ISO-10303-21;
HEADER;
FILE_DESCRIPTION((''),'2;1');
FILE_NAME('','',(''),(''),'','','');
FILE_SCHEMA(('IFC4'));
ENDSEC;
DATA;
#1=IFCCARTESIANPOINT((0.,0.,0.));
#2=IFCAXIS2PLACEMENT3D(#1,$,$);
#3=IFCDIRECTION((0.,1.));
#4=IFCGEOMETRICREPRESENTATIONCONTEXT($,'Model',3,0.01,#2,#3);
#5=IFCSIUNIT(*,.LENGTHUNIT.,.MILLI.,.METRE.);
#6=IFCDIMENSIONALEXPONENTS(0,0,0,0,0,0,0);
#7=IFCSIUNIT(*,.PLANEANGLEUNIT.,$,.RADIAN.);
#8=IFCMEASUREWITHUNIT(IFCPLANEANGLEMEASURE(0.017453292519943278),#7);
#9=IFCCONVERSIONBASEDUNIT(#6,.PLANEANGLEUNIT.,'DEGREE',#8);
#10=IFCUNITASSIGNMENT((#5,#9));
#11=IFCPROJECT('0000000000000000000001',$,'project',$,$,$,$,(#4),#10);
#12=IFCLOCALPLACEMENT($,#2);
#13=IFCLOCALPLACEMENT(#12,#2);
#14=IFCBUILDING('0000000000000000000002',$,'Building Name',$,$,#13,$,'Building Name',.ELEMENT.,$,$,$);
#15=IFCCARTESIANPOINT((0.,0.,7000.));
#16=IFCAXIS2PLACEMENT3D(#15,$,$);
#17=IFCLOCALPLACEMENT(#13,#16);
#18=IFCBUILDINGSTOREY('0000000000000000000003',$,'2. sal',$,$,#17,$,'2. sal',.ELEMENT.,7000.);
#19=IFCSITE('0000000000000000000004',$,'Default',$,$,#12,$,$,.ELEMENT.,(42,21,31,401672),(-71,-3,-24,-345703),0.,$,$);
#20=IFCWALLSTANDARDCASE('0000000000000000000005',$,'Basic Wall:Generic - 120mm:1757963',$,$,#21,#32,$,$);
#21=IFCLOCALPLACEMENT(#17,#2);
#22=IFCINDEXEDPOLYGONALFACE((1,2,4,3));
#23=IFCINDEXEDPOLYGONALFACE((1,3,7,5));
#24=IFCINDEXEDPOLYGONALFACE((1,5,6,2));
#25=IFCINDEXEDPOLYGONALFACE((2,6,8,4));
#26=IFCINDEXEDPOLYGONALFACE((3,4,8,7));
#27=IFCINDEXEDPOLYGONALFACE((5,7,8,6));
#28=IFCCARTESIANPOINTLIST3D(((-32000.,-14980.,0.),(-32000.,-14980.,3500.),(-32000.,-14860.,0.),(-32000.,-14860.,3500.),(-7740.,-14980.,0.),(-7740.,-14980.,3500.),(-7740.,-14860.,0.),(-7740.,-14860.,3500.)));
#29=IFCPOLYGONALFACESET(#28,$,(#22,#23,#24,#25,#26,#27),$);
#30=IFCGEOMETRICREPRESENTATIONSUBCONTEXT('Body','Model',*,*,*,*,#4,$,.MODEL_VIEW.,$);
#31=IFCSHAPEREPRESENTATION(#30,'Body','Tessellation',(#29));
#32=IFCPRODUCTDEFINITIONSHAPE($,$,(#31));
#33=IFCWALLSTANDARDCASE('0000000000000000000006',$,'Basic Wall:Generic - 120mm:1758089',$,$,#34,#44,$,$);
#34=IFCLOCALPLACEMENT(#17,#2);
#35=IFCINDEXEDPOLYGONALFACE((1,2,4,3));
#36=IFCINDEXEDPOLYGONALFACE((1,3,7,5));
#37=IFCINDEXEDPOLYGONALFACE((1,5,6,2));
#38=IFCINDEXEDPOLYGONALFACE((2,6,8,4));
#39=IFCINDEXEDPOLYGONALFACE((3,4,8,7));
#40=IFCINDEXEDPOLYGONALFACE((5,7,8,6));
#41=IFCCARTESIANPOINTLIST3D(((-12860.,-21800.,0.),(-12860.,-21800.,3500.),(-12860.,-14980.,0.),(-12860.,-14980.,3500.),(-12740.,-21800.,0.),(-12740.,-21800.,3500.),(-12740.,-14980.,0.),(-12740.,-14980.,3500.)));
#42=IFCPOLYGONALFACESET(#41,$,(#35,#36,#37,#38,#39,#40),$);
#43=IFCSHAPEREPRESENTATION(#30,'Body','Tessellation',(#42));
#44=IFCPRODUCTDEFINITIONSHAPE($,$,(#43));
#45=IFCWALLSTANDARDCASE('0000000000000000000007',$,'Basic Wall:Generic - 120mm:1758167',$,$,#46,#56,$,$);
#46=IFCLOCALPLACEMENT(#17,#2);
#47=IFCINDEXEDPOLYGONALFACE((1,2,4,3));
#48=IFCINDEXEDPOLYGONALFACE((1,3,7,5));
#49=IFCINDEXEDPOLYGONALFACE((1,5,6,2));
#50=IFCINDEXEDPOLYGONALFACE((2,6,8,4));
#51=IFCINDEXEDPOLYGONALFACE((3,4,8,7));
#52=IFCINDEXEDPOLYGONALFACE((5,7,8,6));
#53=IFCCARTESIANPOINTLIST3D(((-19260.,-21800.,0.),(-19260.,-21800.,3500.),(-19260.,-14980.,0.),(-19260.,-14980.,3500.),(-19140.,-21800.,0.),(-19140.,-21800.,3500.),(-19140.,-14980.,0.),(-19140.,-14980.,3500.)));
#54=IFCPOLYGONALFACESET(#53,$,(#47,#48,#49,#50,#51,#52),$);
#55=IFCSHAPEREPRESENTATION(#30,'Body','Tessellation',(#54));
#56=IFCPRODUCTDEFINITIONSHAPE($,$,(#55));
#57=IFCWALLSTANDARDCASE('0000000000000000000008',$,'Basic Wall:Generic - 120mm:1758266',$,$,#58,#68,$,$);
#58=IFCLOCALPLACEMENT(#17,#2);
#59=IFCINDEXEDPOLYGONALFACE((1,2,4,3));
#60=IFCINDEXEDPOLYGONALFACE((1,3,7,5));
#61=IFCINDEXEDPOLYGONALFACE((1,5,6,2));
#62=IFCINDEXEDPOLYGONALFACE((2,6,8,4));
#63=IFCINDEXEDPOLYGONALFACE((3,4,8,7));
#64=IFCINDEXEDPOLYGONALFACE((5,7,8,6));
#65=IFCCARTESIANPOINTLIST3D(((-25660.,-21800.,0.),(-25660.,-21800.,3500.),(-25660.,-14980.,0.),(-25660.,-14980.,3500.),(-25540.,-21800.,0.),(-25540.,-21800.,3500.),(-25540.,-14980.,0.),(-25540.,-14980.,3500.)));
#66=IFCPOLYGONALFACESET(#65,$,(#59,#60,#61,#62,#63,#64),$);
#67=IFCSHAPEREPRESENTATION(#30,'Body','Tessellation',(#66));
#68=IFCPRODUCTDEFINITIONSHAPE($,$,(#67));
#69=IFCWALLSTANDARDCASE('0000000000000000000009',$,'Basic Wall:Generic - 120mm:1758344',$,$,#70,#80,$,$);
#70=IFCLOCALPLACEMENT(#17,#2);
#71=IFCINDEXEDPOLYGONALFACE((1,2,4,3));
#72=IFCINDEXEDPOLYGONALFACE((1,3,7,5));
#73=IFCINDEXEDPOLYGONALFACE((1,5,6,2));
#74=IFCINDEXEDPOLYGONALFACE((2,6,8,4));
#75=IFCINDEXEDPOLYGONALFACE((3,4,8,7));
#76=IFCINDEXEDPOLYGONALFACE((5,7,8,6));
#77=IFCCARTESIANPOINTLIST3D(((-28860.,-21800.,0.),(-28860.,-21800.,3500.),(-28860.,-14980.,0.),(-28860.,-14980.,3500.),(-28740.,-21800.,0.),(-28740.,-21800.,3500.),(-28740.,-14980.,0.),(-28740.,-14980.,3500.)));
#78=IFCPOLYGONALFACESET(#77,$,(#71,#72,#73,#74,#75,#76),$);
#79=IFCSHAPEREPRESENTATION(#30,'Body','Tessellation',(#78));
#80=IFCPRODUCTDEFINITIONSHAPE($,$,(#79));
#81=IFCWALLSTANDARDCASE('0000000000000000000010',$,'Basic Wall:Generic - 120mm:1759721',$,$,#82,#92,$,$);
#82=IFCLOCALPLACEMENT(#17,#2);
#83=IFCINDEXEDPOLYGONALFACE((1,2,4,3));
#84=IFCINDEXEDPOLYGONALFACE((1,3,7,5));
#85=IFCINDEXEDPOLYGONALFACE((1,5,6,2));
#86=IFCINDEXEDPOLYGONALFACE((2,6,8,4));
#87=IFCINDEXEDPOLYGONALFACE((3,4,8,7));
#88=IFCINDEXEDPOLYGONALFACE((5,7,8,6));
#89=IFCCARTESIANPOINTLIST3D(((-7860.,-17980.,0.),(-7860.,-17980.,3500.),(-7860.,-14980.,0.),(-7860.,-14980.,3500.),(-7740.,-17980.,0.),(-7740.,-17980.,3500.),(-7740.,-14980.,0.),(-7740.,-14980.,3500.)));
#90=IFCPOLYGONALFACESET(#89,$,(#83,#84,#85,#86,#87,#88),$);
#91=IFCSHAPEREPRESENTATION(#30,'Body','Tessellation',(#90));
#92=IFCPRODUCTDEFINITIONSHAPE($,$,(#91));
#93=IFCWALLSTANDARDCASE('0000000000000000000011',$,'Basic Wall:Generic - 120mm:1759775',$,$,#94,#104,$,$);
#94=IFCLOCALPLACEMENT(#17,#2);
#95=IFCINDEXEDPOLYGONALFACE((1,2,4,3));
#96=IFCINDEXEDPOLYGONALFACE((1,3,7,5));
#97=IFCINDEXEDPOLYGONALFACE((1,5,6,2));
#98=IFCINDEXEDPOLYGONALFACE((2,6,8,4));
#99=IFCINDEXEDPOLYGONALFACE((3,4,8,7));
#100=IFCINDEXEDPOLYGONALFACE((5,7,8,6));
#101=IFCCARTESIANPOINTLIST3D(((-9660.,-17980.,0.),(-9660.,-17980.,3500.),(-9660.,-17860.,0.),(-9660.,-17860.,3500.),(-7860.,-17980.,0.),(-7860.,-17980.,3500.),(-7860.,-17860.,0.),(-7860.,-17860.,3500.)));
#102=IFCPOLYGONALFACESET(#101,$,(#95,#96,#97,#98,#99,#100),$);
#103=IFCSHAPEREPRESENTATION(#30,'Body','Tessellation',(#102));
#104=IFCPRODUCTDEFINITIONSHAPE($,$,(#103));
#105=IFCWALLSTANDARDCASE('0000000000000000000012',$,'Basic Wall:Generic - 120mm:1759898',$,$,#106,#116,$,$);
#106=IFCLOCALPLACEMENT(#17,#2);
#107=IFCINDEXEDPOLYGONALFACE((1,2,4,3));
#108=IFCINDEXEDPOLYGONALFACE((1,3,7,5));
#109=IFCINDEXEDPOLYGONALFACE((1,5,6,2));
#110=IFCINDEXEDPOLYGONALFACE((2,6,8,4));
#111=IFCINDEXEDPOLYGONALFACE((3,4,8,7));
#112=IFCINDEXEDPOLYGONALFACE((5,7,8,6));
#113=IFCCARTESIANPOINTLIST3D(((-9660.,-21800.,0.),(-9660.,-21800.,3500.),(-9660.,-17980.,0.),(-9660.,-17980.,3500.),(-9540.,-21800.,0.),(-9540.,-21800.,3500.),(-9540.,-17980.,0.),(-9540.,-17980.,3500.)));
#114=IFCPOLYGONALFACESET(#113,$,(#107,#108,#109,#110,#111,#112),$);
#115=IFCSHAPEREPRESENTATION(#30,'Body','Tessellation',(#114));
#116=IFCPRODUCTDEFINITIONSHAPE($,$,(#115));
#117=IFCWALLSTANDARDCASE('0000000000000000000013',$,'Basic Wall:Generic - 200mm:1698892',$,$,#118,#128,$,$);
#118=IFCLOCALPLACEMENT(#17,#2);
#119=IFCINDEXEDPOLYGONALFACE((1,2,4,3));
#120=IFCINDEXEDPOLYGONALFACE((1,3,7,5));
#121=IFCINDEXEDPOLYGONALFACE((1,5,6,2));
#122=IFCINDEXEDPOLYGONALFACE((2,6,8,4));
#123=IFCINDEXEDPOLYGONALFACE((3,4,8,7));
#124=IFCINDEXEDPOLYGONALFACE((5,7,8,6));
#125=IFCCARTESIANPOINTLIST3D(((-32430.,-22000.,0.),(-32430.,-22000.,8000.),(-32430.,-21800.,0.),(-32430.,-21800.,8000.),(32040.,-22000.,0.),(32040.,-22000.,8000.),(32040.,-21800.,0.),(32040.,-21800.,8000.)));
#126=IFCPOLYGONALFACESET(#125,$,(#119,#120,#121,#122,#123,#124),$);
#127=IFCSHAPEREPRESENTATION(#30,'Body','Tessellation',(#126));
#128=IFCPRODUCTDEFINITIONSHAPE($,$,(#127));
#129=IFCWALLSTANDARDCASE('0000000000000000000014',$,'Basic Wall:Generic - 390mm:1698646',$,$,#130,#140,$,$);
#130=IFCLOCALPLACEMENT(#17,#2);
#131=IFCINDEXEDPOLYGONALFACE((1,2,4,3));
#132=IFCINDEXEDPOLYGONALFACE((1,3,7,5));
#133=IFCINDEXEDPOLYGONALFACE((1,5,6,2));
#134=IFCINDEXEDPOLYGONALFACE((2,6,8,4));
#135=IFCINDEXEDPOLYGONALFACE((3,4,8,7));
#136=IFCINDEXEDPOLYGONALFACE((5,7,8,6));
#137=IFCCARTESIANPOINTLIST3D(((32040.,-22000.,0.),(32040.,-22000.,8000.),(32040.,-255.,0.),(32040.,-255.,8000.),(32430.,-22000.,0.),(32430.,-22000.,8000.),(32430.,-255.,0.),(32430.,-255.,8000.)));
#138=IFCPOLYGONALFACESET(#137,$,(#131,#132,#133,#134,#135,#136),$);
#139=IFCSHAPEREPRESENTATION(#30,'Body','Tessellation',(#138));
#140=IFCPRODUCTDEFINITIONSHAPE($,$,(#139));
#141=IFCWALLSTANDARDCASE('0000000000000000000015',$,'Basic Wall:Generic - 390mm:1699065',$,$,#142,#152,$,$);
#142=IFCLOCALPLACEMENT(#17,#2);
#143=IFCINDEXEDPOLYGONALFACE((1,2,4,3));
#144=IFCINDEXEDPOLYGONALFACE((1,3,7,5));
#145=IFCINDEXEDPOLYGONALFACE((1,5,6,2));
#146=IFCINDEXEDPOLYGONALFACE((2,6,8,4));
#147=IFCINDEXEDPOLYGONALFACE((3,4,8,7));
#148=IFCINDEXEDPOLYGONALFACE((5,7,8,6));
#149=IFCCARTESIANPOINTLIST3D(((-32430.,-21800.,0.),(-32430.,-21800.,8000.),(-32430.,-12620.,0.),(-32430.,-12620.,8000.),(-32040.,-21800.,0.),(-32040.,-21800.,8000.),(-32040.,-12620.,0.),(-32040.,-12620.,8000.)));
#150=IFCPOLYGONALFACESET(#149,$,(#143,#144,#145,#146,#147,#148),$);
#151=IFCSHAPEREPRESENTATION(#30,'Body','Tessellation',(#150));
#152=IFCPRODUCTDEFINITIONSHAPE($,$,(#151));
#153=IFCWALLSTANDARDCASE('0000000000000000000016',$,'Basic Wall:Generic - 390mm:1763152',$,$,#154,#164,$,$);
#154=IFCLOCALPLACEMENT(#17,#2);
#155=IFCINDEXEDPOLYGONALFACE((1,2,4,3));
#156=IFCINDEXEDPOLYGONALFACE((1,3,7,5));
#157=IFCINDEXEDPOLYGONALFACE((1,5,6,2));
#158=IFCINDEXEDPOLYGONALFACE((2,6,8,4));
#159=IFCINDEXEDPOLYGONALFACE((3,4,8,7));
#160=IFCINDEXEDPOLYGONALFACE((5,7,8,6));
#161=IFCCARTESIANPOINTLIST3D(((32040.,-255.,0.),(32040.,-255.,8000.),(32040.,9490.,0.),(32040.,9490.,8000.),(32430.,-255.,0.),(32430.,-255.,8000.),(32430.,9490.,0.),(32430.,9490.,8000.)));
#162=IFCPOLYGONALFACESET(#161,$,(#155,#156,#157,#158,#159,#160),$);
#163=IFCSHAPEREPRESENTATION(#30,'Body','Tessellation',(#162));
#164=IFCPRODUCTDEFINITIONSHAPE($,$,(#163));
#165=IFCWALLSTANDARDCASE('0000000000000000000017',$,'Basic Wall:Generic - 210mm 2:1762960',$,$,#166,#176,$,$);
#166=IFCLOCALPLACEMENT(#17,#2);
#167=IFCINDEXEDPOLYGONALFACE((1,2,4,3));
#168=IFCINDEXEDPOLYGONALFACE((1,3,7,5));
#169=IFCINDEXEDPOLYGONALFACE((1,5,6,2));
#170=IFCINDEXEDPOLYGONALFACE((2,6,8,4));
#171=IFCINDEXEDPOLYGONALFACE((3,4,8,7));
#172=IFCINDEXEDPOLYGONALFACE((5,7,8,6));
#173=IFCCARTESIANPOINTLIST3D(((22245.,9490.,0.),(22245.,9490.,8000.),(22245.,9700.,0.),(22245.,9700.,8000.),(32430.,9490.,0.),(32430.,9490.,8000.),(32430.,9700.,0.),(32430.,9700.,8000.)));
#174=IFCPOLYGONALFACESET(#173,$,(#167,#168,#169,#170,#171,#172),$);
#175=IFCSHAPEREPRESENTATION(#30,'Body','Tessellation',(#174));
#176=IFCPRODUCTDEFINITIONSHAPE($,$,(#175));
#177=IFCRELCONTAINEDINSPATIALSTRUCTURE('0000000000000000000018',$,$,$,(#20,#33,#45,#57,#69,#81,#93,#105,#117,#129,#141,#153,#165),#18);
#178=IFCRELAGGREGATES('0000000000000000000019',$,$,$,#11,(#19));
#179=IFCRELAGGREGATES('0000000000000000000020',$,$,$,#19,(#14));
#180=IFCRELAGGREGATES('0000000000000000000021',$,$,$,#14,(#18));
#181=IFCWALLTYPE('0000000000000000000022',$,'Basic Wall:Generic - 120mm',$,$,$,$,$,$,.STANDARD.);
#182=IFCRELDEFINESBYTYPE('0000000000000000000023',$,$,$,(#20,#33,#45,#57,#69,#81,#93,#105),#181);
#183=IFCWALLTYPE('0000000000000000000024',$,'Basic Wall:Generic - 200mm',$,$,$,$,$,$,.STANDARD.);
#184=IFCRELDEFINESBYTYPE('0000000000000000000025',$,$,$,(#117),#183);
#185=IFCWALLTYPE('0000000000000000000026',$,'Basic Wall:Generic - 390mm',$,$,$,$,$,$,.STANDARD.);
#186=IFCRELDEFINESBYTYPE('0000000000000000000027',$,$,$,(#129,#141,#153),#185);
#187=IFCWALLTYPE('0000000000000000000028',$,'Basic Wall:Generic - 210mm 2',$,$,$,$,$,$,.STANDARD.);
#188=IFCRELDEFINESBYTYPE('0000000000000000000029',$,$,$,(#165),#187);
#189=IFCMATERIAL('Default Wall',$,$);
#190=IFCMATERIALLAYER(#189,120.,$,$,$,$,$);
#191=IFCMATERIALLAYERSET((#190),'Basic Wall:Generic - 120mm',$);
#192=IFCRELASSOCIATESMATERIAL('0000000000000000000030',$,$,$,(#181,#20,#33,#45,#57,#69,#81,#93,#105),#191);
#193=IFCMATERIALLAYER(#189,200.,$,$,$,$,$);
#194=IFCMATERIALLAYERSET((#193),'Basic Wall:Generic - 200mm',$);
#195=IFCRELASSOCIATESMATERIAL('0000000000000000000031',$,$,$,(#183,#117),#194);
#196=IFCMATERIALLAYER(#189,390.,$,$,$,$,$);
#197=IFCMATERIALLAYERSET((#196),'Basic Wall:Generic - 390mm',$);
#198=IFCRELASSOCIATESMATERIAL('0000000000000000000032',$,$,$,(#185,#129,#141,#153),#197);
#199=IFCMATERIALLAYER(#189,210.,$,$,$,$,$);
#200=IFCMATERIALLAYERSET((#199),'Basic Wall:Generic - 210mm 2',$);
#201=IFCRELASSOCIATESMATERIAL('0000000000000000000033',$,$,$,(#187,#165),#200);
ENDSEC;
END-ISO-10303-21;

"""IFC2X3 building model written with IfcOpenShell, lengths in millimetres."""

from ifc_helpers import new_model, entity, si_unit, converted_unit, direction, frame, frame_2d, origin, place, context, subcontext, project, spatial, rectangle, extrude, material, layer, layer_set, layer_usage, type_object, element, save


model = new_model("IFC2X3")

# Units and contexts
model_context = context("Model", 3, precision=0.01, world=origin(), true_north=direction((0.0, 1.0)))
body_context = subcontext(model_context, "Body", "Model", "MODEL_VIEW")
ifc_project = project(units=[si_unit("LENGTHUNIT", "METRE", prefix="MILLI"), converted_unit("PLANEANGLEUNIT", "DEGREE", entity("IfcPlaneAngleMeasure", 0.017453292519943278), si_unit("PLANEANGLEUNIT", "RADIAN"), dimensions=[0, 0, 0, 0, 0, 0, 0])], contexts=[model_context])

# Site, building, storey
site_placement = place(None, origin())
site = spatial("IfcSite", under=ifc_project, at=site_placement, Name="Default", CompositionType="ELEMENT", RefLatitude=(42, 21, 31, 401672), RefLongitude=(-71, -3, -24, -345703), RefElevation=0.0)
building_placement = place(site_placement, origin())
building = spatial("IfcBuilding", under=site, at=building_placement, Name="Building Name", LongName="Building Name", CompositionType="ELEMENT")
storey_placement = place(building_placement, frame((0.0, 0.0, 7000.0)))
storey = spatial("IfcBuildingStorey", under=building, at=storey_placement, Name="2. sal", LongName="2. sal", CompositionType="ELEMENT", Elevation=7000.0)

# Walls
ifc_material_1 = material(Name="Default Wall")
ifc_layer_1 = layer(ifc_material_1, 120.0)
ifc_layer_set_1 = layer_set([ifc_layer_1], Name="Basic Wall:Generic - 120mm")
ifc_layer_usage_1 = layer_usage(ifc_layer_set_1, "AXIS2", "NEGATIVE", 60.0)
wall_type_1 = type_object("IfcWallType", Name="Basic Wall:Generic - 120mm", PredefinedType="STANDARD", material=ifc_layer_set_1)
wall_1_placement = place(storey_placement, frame((-32000.0, -14920.0, 0.0)))
element("IfcWallStandardCase", 1, at=wall_1_placement, inside=storey, type_object=wall_type_1, material=ifc_layer_usage_1, Name="Basic Wall:Generic - 120mm:1757963", context=body_context, shape_type="SweptSolid", body=[
    extrude(rectangle(XDim=24260.0, YDim=120.0, at=frame_2d((12130.0, 0.0), x_axis=(-1.0, 0.0))), origin(), (0.0, 0.0, 1.0), 3500.0),
])
ifc_layer_usage_2 = layer_usage(ifc_layer_set_1, "AXIS2", "NEGATIVE", 60.0)
wall_2_placement = place(storey_placement, frame((-12800.0, -14980.0, 0.0), z_axis=(0.0, 0.0, 1.0), x_axis=(0.0, -1.0, 0.0)))
element("IfcWallStandardCase", 2, at=wall_2_placement, inside=storey, type_object=wall_type_1, material=ifc_layer_usage_2, Name="Basic Wall:Generic - 120mm:1758089", context=body_context, shape_type="SweptSolid", body=[
    extrude(rectangle(XDim=6820.0, YDim=120.0, at=frame_2d((3410.0, 0.0), x_axis=(-1.0, 0.0))), origin(), (0.0, 0.0, 1.0), 3500.0),
])
ifc_layer_usage_3 = layer_usage(ifc_layer_set_1, "AXIS2", "NEGATIVE", 60.0)
wall_3_placement = place(storey_placement, frame((-19200.0, -14980.0, 0.0), z_axis=(0.0, 0.0, 1.0), x_axis=(0.0, -1.0, 0.0)))
element("IfcWallStandardCase", 3, at=wall_3_placement, inside=storey, type_object=wall_type_1, material=ifc_layer_usage_3, Name="Basic Wall:Generic - 120mm:1758167", context=body_context, shape_type="SweptSolid", body=[
    extrude(rectangle(XDim=6820.0, YDim=120.0, at=frame_2d((3410.0, 0.0), x_axis=(-1.0, 0.0))), origin(), (0.0, 0.0, 1.0), 3500.0),
])
ifc_layer_usage_4 = layer_usage(ifc_layer_set_1, "AXIS2", "NEGATIVE", 60.0)
wall_4_placement = place(storey_placement, frame((-25600.0, -14980.0, 0.0), z_axis=(0.0, 0.0, 1.0), x_axis=(0.0, -1.0, 0.0)))
element("IfcWallStandardCase", 4, at=wall_4_placement, inside=storey, type_object=wall_type_1, material=ifc_layer_usage_4, Name="Basic Wall:Generic - 120mm:1758266", context=body_context, shape_type="SweptSolid", body=[
    extrude(rectangle(XDim=6820.0, YDim=120.0, at=frame_2d((3410.0, 0.0), x_axis=(-1.0, 0.0))), origin(), (0.0, 0.0, 1.0), 3500.0),
])
ifc_layer_usage_5 = layer_usage(ifc_layer_set_1, "AXIS2", "NEGATIVE", 60.0)
wall_5_placement = place(storey_placement, frame((-28800.0, -14980.0, 0.0), z_axis=(0.0, 0.0, 1.0), x_axis=(0.0, -1.0, 0.0)))
element("IfcWallStandardCase", 5, at=wall_5_placement, inside=storey, type_object=wall_type_1, material=ifc_layer_usage_5, Name="Basic Wall:Generic - 120mm:1758344", context=body_context, shape_type="SweptSolid", body=[
    extrude(rectangle(XDim=6820.0, YDim=120.0, at=frame_2d((3410.0, 0.0), x_axis=(-1.0, 0.0))), origin(), (0.0, 0.0, 1.0), 3500.0),
])
ifc_layer_usage_6 = layer_usage(ifc_layer_set_1, "AXIS2", "NEGATIVE", 60.0)
wall_6_placement = place(storey_placement, frame((-7800.0, -14980.0, 0.0), z_axis=(0.0, 0.0, 1.0), x_axis=(0.0, -1.0, 0.0)))
element("IfcWallStandardCase", 6, at=wall_6_placement, inside=storey, type_object=wall_type_1, material=ifc_layer_usage_6, Name="Basic Wall:Generic - 120mm:1759721", context=body_context, shape_type="SweptSolid", body=[
    extrude(rectangle(XDim=3000.0, YDim=120.0, at=frame_2d((1500.0, 0.0), x_axis=(-1.0, 0.0))), origin(), (0.0, 0.0, 1.0), 3500.0),
])
ifc_layer_usage_7 = layer_usage(ifc_layer_set_1, "AXIS2", "NEGATIVE", 60.0)
wall_7_placement = place(storey_placement, frame((-7860.0, -17920.0, 0.0), z_axis=(0.0, 0.0, 1.0), x_axis=(-1.0, 0.0, 0.0)))
element("IfcWallStandardCase", 7, at=wall_7_placement, inside=storey, type_object=wall_type_1, material=ifc_layer_usage_7, Name="Basic Wall:Generic - 120mm:1759775", context=body_context, shape_type="SweptSolid", body=[
    extrude(rectangle(XDim=1800.0, YDim=120.0, at=frame_2d((900.0, 0.0), x_axis=(-1.0, 0.0))), origin(), (0.0, 0.0, 1.0), 3500.0),
])
ifc_layer_usage_8 = layer_usage(ifc_layer_set_1, "AXIS2", "NEGATIVE", 60.0)
wall_8_placement = place(storey_placement, frame((-9600.0, -17980.0, 0.0), z_axis=(0.0, 0.0, 1.0), x_axis=(0.0, -1.0, 0.0)))
element("IfcWallStandardCase", 8, at=wall_8_placement, inside=storey, type_object=wall_type_1, material=ifc_layer_usage_8, Name="Basic Wall:Generic - 120mm:1759898", context=body_context, shape_type="SweptSolid", body=[
    extrude(rectangle(XDim=3820.0, YDim=120.0, at=frame_2d((1910.0, 0.0), x_axis=(-1.0, 0.0))), origin(), (0.0, 0.0, 1.0), 3500.0),
])
ifc_layer_2 = layer(ifc_material_1, 200.0)
ifc_layer_set_2 = layer_set([ifc_layer_2], Name="Basic Wall:Generic - 200mm")
ifc_layer_usage_9 = layer_usage(ifc_layer_set_2, "AXIS2", "NEGATIVE", 100.0)
wall_type_2 = type_object("IfcWallType", Name="Basic Wall:Generic - 200mm", PredefinedType="STANDARD", material=ifc_layer_set_2)
wall_9_placement = place(storey_placement, frame((32040.0, -21900.0, 0.0), z_axis=(0.0, 0.0, 1.0), x_axis=(-1.0, 0.0, 0.0)))
element("IfcWallStandardCase", 9, at=wall_9_placement, inside=storey, type_object=wall_type_2, material=ifc_layer_usage_9, Name="Basic Wall:Generic - 200mm:1698892", context=body_context, shape_type="SweptSolid", body=[
    extrude(rectangle(XDim=64470.0, YDim=200.0, at=frame_2d((32235.0, 0.0), x_axis=(-1.0, 0.0))), origin(), (0.0, 0.0, 1.0), 8000.0),
])
ifc_layer_3 = layer(ifc_material_1, 390.0)
ifc_layer_set_3 = layer_set([ifc_layer_3], Name="Basic Wall:Generic - 390mm")
ifc_layer_usage_10 = layer_usage(ifc_layer_set_3, "AXIS2", "NEGATIVE", 195.0)
wall_type_3 = type_object("IfcWallType", Name="Basic Wall:Generic - 390mm", PredefinedType="STANDARD", material=ifc_layer_set_3)
wall_10_placement = place(storey_placement, frame((32235.0, -255.0, 0.0), z_axis=(0.0, 0.0, 1.0), x_axis=(0.0, -1.0, 0.0)))
element("IfcWallStandardCase", 10, at=wall_10_placement, inside=storey, type_object=wall_type_3, material=ifc_layer_usage_10, Name="Basic Wall:Generic - 390mm:1698646", context=body_context, shape_type="SweptSolid", body=[
    extrude(rectangle(XDim=21745.0, YDim=390.0, at=frame_2d((10872.5, 0.0), x_axis=(-1.0, 0.0))), origin(), (0.0, 0.0, 1.0), 8000.0),
])
ifc_layer_usage_11 = layer_usage(ifc_layer_set_3, "AXIS2", "NEGATIVE", 195.0)
wall_11_placement = place(storey_placement, frame((-32235.0, -21800.0, 0.0), z_axis=(0.0, 0.0, 1.0), x_axis=(0.0, 1.0, 0.0)))
element("IfcWallStandardCase", 11, at=wall_11_placement, inside=storey, type_object=wall_type_3, material=ifc_layer_usage_11, Name="Basic Wall:Generic - 390mm:1699065", context=body_context, shape_type="SweptSolid", body=[
    extrude(rectangle(XDim=9180.0, YDim=390.0, at=frame_2d((4590.0, 0.0), x_axis=(-1.0, 0.0))), origin(), (0.0, 0.0, 1.0), 8000.0),
])
ifc_layer_usage_12 = layer_usage(ifc_layer_set_3, "AXIS2", "NEGATIVE", 195.0)
wall_12_placement = place(storey_placement, frame((32235.0, -255.0, 0.0), z_axis=(0.0, 0.0, 1.0), x_axis=(0.0, 1.0, 0.0)))
element("IfcWallStandardCase", 12, at=wall_12_placement, inside=storey, type_object=wall_type_3, material=ifc_layer_usage_12, Name="Basic Wall:Generic - 390mm:1763152", context=body_context, shape_type="SweptSolid", body=[
    extrude(rectangle(XDim=9745.0, YDim=390.0, at=frame_2d((4872.5, 0.0), x_axis=(-1.0, 0.0))), origin(), (0.0, 0.0, 1.0), 8000.0),
])
ifc_layer_4 = layer(ifc_material_1, 210.0)
ifc_layer_set_4 = layer_set([ifc_layer_4], Name="Basic Wall:Generic - 210mm 2")
ifc_layer_usage_13 = layer_usage(ifc_layer_set_4, "AXIS2", "NEGATIVE", 105.0)
wall_type_4 = type_object("IfcWallType", Name="Basic Wall:Generic - 210mm 2", PredefinedType="STANDARD", material=ifc_layer_set_4)
wall_13_placement = place(storey_placement, frame((22245.0, 9595.0, 0.0)))
element("IfcWallStandardCase", 13, at=wall_13_placement, inside=storey, type_object=wall_type_4, material=ifc_layer_usage_13, Name="Basic Wall:Generic - 210mm 2:1762960", context=body_context, shape_type="SweptSolid", body=[
    extrude(rectangle(XDim=10185.0, YDim=210.0, at=frame_2d((5092.5, 0.0), x_axis=(-1.0, 0.0))), origin(), (0.0, 0.0, 1.0), 8000.0),
])

save(model, "model.ifc")
